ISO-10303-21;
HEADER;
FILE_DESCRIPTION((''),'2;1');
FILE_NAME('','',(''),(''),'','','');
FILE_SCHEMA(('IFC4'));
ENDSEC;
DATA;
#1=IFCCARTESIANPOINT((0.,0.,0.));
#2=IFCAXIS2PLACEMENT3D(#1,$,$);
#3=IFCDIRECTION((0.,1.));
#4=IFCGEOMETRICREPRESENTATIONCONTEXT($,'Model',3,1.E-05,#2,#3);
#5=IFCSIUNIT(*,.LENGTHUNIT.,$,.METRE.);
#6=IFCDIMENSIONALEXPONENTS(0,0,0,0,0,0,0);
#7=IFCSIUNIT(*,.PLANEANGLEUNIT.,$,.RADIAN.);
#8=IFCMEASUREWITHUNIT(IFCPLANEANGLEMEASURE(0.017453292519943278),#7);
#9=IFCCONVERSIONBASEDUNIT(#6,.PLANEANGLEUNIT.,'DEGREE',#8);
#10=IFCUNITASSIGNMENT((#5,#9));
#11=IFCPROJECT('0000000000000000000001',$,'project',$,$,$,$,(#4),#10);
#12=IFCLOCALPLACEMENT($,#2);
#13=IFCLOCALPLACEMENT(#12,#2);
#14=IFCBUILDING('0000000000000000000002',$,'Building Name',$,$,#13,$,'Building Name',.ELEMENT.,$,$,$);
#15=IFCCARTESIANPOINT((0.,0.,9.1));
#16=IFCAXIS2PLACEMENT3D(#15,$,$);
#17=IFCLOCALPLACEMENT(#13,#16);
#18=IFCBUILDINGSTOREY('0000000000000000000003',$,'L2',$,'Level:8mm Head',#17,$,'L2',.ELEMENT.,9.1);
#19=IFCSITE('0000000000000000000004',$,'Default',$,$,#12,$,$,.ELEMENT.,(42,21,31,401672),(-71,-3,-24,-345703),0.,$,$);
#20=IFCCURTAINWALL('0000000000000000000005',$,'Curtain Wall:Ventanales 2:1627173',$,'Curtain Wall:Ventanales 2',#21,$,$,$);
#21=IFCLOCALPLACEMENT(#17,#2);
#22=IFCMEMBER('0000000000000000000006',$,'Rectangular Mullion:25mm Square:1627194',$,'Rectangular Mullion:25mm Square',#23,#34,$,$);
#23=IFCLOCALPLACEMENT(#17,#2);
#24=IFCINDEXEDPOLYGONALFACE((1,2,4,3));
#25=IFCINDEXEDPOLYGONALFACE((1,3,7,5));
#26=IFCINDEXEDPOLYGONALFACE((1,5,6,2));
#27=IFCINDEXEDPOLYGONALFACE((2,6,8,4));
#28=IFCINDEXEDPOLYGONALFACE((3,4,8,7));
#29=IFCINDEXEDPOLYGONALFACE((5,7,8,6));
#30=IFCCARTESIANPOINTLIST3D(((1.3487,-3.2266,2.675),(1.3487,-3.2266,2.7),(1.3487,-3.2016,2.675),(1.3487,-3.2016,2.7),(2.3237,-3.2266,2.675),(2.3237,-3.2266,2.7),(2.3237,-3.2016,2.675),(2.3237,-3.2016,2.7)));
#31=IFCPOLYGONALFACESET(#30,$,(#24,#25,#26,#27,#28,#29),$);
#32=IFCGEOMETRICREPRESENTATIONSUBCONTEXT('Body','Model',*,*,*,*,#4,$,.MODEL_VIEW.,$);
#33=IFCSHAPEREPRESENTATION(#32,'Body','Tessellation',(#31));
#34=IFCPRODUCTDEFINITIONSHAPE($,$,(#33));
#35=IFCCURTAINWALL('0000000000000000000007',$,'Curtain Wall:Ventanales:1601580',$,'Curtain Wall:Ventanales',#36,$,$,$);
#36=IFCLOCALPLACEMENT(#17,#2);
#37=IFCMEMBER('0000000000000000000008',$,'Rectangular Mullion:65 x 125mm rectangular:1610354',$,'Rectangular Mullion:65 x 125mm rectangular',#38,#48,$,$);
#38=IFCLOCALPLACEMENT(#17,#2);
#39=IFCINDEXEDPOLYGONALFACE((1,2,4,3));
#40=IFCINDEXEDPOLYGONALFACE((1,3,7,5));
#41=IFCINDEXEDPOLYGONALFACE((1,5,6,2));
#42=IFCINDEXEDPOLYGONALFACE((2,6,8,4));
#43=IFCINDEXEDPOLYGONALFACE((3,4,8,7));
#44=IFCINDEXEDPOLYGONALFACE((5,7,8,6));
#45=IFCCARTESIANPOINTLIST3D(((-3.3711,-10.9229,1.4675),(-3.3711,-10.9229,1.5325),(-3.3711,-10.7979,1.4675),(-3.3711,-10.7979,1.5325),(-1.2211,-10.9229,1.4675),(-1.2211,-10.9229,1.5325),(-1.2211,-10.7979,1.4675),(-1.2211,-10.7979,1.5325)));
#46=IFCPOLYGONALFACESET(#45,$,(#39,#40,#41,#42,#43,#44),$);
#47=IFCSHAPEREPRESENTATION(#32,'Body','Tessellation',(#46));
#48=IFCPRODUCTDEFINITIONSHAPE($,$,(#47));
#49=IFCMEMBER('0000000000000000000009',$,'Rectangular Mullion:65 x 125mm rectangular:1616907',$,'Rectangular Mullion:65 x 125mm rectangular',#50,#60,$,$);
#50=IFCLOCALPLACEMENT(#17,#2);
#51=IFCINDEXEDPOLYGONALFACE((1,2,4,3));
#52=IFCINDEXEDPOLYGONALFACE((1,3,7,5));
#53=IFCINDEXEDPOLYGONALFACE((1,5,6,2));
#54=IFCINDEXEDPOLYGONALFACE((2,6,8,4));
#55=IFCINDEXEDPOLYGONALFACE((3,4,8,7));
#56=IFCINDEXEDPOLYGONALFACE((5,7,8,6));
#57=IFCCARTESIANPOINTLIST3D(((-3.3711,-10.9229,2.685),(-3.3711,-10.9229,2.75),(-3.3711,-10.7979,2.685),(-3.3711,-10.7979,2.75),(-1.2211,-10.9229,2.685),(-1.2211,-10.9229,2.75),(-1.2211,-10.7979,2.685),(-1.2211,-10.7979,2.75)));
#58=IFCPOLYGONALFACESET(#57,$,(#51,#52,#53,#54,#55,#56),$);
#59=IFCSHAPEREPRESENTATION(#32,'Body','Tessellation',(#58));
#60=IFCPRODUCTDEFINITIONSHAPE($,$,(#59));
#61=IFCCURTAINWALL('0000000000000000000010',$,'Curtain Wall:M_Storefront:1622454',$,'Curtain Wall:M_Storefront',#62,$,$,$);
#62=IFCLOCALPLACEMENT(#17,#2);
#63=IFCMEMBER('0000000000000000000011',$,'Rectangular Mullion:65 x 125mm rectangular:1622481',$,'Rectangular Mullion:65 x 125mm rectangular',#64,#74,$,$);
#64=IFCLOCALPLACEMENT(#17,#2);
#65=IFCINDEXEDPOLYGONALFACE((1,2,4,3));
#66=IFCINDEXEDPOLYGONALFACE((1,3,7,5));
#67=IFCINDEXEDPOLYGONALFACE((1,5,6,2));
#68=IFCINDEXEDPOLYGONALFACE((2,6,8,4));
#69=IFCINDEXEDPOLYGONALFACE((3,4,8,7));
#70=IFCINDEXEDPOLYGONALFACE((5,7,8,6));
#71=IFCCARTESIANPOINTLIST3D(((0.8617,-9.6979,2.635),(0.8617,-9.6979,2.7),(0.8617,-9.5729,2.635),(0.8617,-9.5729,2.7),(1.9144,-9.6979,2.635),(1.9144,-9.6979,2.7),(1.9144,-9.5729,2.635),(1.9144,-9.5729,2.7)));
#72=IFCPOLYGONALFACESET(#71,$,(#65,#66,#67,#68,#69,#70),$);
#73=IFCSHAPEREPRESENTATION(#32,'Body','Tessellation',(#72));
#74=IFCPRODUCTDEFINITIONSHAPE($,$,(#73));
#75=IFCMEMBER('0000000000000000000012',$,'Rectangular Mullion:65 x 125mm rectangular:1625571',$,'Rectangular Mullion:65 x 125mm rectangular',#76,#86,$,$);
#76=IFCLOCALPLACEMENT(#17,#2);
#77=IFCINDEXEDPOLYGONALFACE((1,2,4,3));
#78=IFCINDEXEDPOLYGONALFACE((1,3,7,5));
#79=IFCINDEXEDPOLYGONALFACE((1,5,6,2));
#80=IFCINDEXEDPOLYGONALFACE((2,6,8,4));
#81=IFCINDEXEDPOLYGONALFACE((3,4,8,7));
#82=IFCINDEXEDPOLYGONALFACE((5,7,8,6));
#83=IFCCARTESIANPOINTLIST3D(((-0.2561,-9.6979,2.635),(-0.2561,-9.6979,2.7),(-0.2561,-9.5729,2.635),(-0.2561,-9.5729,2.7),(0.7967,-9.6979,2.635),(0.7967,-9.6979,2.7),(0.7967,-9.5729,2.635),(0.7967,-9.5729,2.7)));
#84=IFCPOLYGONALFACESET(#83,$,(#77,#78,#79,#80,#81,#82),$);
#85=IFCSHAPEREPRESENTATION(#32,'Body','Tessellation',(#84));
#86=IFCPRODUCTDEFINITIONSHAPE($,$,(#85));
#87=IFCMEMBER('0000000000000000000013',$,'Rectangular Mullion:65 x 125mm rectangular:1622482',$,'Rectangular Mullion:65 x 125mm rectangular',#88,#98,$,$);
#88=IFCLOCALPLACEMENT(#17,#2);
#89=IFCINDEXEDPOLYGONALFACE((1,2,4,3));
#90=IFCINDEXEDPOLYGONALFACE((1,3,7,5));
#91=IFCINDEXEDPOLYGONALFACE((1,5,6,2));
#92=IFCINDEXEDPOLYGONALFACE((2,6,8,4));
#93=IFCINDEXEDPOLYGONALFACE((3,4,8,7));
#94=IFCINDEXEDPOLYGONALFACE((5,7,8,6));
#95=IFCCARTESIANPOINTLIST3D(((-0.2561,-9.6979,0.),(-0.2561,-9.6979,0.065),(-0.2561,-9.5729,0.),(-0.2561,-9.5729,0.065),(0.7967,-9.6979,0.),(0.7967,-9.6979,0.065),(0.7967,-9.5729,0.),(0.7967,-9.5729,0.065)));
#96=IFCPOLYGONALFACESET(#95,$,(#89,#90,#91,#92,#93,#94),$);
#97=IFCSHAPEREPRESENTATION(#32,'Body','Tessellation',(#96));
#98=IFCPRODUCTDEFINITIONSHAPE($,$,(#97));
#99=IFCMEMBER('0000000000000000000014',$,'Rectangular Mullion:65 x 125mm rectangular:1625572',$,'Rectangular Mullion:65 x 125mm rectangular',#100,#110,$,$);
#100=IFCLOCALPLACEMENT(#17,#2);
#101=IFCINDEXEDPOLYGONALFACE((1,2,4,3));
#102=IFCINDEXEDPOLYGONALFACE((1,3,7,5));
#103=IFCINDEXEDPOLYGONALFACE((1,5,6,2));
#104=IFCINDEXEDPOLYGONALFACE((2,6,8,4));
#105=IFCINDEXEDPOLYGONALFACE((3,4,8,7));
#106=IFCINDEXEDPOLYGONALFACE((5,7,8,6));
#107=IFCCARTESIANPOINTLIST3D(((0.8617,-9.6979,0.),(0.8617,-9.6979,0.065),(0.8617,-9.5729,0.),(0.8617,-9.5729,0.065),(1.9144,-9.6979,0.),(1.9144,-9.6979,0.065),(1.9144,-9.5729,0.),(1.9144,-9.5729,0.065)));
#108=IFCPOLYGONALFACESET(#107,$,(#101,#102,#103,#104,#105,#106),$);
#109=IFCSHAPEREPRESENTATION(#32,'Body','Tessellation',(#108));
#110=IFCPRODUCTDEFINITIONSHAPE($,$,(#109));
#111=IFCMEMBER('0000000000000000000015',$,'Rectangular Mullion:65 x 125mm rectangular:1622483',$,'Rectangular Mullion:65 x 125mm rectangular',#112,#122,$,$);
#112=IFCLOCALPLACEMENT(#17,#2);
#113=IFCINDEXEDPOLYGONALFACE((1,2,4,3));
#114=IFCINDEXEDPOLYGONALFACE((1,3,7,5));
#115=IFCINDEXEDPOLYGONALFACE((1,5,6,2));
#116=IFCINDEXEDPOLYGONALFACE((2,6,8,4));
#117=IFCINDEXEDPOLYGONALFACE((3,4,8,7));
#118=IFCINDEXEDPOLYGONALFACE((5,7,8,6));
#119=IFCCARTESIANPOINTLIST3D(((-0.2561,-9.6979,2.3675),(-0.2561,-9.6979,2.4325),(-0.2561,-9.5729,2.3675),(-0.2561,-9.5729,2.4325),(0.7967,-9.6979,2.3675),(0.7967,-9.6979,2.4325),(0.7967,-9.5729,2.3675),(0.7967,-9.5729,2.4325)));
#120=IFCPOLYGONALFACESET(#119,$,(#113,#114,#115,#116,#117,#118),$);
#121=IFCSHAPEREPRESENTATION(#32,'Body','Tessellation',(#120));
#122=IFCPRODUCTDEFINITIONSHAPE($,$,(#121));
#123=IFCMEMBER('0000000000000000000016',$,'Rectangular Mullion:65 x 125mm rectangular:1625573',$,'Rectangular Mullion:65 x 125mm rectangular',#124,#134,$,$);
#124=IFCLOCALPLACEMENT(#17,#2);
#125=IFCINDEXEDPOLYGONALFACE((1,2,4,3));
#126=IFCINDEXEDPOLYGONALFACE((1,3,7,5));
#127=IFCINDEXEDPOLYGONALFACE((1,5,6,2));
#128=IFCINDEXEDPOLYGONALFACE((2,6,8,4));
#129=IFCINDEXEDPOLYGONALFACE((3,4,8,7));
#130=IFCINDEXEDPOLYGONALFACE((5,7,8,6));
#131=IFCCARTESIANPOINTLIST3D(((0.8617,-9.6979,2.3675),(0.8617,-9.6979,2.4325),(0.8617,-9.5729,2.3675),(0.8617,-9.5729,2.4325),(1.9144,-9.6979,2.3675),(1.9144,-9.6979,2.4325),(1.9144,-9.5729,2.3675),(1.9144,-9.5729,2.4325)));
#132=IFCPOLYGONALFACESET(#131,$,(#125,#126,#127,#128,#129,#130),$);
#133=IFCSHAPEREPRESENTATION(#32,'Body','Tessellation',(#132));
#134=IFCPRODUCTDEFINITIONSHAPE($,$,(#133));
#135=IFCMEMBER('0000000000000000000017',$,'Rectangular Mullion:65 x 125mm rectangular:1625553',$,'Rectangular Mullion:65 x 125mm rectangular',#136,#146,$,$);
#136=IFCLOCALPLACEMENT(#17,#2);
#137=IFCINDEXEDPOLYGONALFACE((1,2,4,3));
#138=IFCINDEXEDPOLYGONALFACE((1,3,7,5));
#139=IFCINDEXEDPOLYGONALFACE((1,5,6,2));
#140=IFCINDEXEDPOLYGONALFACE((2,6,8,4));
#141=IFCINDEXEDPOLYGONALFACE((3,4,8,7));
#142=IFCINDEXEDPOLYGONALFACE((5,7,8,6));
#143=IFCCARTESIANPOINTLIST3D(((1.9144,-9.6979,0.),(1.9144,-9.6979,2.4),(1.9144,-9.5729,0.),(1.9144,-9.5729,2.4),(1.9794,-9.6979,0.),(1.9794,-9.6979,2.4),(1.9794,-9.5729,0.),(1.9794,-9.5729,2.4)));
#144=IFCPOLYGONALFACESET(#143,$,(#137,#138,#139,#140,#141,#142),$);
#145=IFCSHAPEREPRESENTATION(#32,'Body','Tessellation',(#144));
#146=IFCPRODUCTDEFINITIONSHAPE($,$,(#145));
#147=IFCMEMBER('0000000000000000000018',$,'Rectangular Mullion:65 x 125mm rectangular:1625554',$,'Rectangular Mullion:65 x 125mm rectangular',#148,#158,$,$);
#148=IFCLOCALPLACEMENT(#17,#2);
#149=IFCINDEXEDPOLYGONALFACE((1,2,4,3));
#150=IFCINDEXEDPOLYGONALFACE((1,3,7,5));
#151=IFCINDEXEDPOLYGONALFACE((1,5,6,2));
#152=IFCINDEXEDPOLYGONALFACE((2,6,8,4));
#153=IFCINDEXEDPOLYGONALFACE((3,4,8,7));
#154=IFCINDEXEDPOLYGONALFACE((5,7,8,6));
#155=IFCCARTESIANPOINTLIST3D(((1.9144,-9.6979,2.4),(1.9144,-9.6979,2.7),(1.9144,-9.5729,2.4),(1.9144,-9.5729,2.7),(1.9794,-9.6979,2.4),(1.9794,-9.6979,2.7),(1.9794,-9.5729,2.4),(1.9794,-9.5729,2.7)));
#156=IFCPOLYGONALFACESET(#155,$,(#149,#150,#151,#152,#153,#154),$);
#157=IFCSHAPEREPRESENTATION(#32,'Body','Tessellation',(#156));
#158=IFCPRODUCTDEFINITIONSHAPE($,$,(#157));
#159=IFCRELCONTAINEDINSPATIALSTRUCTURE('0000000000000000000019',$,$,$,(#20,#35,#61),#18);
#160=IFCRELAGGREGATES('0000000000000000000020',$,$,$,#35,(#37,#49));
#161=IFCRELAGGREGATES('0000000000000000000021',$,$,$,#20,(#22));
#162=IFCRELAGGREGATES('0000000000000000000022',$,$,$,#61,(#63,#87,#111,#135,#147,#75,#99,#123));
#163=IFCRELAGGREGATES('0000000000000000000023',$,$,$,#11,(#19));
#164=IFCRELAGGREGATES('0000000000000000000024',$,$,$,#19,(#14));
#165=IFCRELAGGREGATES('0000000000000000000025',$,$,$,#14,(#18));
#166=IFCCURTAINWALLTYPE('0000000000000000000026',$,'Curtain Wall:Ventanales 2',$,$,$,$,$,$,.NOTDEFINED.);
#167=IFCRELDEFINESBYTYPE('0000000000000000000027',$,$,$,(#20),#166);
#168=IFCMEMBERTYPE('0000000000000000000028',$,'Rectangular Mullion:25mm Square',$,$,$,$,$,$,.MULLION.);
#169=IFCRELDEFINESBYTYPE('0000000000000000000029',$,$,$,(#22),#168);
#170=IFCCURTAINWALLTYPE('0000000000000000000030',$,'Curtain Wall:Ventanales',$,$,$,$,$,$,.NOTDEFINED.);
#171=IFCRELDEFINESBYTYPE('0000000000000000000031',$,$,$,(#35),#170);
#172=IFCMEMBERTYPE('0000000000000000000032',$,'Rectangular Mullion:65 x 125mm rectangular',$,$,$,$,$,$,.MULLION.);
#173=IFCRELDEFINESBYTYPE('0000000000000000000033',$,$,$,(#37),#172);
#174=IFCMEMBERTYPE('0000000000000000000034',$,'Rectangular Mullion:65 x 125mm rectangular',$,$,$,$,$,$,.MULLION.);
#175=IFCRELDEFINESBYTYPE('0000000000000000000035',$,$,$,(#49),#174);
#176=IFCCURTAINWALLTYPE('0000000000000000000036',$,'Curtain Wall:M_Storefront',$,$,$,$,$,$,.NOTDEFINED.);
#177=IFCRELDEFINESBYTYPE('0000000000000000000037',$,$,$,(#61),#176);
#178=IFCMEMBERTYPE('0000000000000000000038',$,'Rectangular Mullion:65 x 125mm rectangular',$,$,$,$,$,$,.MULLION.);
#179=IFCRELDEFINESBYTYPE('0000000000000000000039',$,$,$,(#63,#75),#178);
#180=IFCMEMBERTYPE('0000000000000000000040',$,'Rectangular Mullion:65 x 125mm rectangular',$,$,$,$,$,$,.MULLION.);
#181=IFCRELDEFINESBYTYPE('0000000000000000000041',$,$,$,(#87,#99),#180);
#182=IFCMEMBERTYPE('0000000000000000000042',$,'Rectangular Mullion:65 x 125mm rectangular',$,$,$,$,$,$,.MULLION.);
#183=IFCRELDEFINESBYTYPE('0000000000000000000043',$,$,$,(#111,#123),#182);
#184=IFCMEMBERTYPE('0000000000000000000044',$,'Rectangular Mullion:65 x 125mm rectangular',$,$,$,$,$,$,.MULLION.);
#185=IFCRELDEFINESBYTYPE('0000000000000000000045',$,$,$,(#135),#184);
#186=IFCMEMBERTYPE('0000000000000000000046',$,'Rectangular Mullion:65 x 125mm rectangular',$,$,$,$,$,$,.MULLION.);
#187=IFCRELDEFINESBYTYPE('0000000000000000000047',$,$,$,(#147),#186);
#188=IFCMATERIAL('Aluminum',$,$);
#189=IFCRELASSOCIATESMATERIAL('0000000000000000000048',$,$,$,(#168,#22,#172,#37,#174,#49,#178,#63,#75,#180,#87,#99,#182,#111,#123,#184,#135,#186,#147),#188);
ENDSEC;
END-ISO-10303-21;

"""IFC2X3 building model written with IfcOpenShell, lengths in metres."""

from ifc_helpers import new_model, entity, si_unit, converted_unit, direction, frame, origin, origin_2d_with_axis, place, context, subcontext, project, spatial, rectangle, extrude, source, transform, mapped, material, type_object, type_shapes, element, aggregate, save


model = new_model("IFC2X3")

# Units and contexts
model_context = context("Model", 3, precision=1e-05, world=origin(), true_north=direction((0.0, 1.0)))
body_context = subcontext(model_context, "Body", "Model", "MODEL_VIEW")
ifc_project = project(units=[si_unit("LENGTHUNIT", "METRE"), converted_unit("PLANEANGLEUNIT", "DEGREE", entity("IfcPlaneAngleMeasure", 0.017453292519943278), si_unit("PLANEANGLEUNIT", "RADIAN"), dimensions=[0, 0, 0, 0, 0, 0, 0])], contexts=[model_context])

# Site, building, storey
site_placement = place(None, origin())
site = spatial("IfcSite", under=ifc_project, at=site_placement, Name="Default", CompositionType="ELEMENT", RefLatitude=(42, 21, 31, 401672), RefLongitude=(-71, -3, -24, -345703), RefElevation=0.0)
building_placement = place(site_placement, origin())
building = spatial("IfcBuilding", under=site, at=building_placement, Name="Building Name", LongName="Building Name", CompositionType="ELEMENT")
storey_placement = place(building_placement, frame((0.0, 0.0, 9.1)))
storey = spatial("IfcBuildingStorey", under=building, at=storey_placement, Name="L2", ObjectType="Level:8mm Head", LongName="L2", CompositionType="ELEMENT", Elevation=9.1)

# Curtain wall, member
curtain_wall_type_1 = type_object("IfcCurtainWallType", Name="Curtain Wall:Ventanales 2", PredefinedType="NOTDEFINED")
curtain_wall_1_placement = place(storey_placement, frame((0.0, 0.0, -9.1)))
curtain_wall_1 = element("IfcCurtainWall", 1, at=curtain_wall_1_placement, inside=storey, type_object=curtain_wall_type_1, Name="Curtain Wall:Ventanales 2:1627173", ObjectType="Curtain Wall:Ventanales 2")
ifc_material_1 = material(Name="Aluminum")
member_type_1 = type_object("IfcMemberType", Name="Rectangular Mullion:25mm Square", PredefinedType="MULLION", material=ifc_material_1)
shared_shape_1 = source(origin(), body_context, "Body", "SweptSolid", [
    extrude(rectangle(XDim=0.025, YDim=0.025, at=origin_2d_with_axis()), frame((-0.0125, 0.0, -0.975), z_axis=(0.0, 0.0, 1.0), x_axis=(-1.0, 0.0, 0.0)), (0.0, 0.0, 1.0), 0.975),
])
type_shapes(member_type_1, [shared_shape_1])
member_1_placement = place(curtain_wall_1_placement, frame((2.3237, -3.2141, 11.8), z_axis=(1.0, 0.0, 0.0), x_axis=(0.0, 0.0, 1.0)))
member_1 = element("IfcMember", 2, at=member_1_placement, type_object=member_type_1, material=ifc_material_1, Name="Rectangular Mullion:25mm Square:1627194", ObjectType="Rectangular Mullion:25mm Square", context=body_context, shape_type="MappedRepresentation", body=[
    mapped(shared_shape_1, transform((0.0, 0.0, 0.0), scale=1.0)),
])

# Curtain walls, members
curtain_wall_type_2 = type_object("IfcCurtainWallType", Name="Curtain Wall:Ventanales", PredefinedType="NOTDEFINED")
curtain_wall_2_placement = place(storey_placement, frame((0.0, 0.0, -9.1)))
curtain_wall_2 = element("IfcCurtainWall", 3, at=curtain_wall_2_placement, inside=storey, type_object=curtain_wall_type_2, Name="Curtain Wall:Ventanales:1601580", ObjectType="Curtain Wall:Ventanales")
member_type_2 = type_object("IfcMemberType", Name="Rectangular Mullion:65 x 125mm rectangular", PredefinedType="MULLION", material=ifc_material_1)
shared_shape_2 = source(origin(), body_context, "Body", "SweptSolid", [
    extrude(rectangle(XDim=0.065, YDim=0.125, at=origin_2d_with_axis()), frame((0.0, 0.0, -2.15), z_axis=(0.0, 0.0, 1.0), x_axis=(-1.0, 0.0, 0.0)), (0.0, 0.0, 1.0), 2.15),
])
type_shapes(member_type_2, [shared_shape_2])
member_2_placement = place(curtain_wall_2_placement, frame((-1.2211, -10.8604, 10.6), z_axis=(1.0, 0.0, 0.0), x_axis=(0.0, 0.0, 1.0)))
member_2 = element("IfcMember", 4, at=member_2_placement, type_object=member_type_2, material=ifc_material_1, Name="Rectangular Mullion:65 x 125mm rectangular:1610354", ObjectType="Rectangular Mullion:65 x 125mm rectangular", context=body_context, shape_type="MappedRepresentation", body=[
    mapped(shared_shape_2, transform((0.0, 0.0, 0.0), scale=1.0)),
])
member_type_3 = type_object("IfcMemberType", Name="Rectangular Mullion:65 x 125mm rectangular", PredefinedType="MULLION", material=ifc_material_1)
shared_shape_3 = source(origin(), body_context, "Body", "SweptSolid", [
    extrude(rectangle(XDim=0.065, YDim=0.125, at=origin_2d_with_axis()), frame((-0.0325, 0.0, -2.15), z_axis=(0.0, 0.0, 1.0), x_axis=(-1.0, 0.0, 0.0)), (0.0, 0.0, 1.0), 2.15),
])
type_shapes(member_type_3, [shared_shape_3])
member_3_placement = place(curtain_wall_2_placement, frame((-1.2211, -10.8604, 11.85), z_axis=(1.0, 0.0, 0.0), x_axis=(0.0, 0.0, 1.0)))
member_3 = element("IfcMember", 5, at=member_3_placement, type_object=member_type_3, material=ifc_material_1, Name="Rectangular Mullion:65 x 125mm rectangular:1616907", ObjectType="Rectangular Mullion:65 x 125mm rectangular", context=body_context, shape_type="MappedRepresentation", body=[
    mapped(shared_shape_3, transform((0.0, 0.0, 0.0), scale=1.0)),
])
aggregate(curtain_wall_2, [member_2, member_3])
curtain_wall_type_3 = type_object("IfcCurtainWallType", Name="Curtain Wall:M_Storefront", PredefinedType="NOTDEFINED")
curtain_wall_3_placement = place(storey_placement, frame((0.0, 0.0, -9.1)))
curtain_wall_3 = element("IfcCurtainWall", 6, at=curtain_wall_3_placement, inside=storey, type_object=curtain_wall_type_3, Name="Curtain Wall:M_Storefront:1622454", ObjectType="Curtain Wall:M_Storefront")
member_type_4 = type_object("IfcMemberType", Name="Rectangular Mullion:65 x 125mm rectangular", PredefinedType="MULLION", material=ifc_material_1)
shared_shape_4 = source(origin(), body_context, "Body", "SweptSolid", [
    extrude(rectangle(XDim=0.065, YDim=0.125, at=origin_2d_with_axis()), frame((-0.0325, 0.0, -1.0528), z_axis=(0.0, 0.0, 1.0), x_axis=(-1.0, 0.0, 0.0)), (0.0, 0.0, 1.0), 1.0528),
])
type_shapes(member_type_4, [shared_shape_4])
member_4_placement = place(curtain_wall_3_placement, frame((1.9144, -9.6354, 11.8), z_axis=(1.0, 0.0, 0.0), x_axis=(0.0, 0.0, 1.0)))
member_4 = element("IfcMember", 7, at=member_4_placement, type_object=member_type_4, material=ifc_material_1, Name="Rectangular Mullion:65 x 125mm rectangular:1622481", ObjectType="Rectangular Mullion:65 x 125mm rectangular", context=body_context, shape_type="MappedRepresentation", body=[
    mapped(shared_shape_4, transform((0.0, 0.0, 0.0), scale=1.0)),
])
member_5_placement = place(curtain_wall_3_placement, frame((0.7967, -9.6354, 11.8), z_axis=(1.0, 0.0, 0.0), x_axis=(0.0, 0.0, 1.0)))
member_5 = element("IfcMember", 8, at=member_5_placement, type_object=member_type_4, material=ifc_material_1, Name="Rectangular Mullion:65 x 125mm rectangular:1625571", ObjectType="Rectangular Mullion:65 x 125mm rectangular", context=body_context, shape_type="MappedRepresentation", body=[
    mapped(shared_shape_4, transform((0.0, 0.0, 0.0), scale=1.0)),
])
member_type_5 = type_object("IfcMemberType", Name="Rectangular Mullion:65 x 125mm rectangular", PredefinedType="MULLION", material=ifc_material_1)
shared_shape_5 = source(origin(), body_context, "Body", "SweptSolid", [
    extrude(rectangle(XDim=0.065, YDim=0.125, at=origin_2d_with_axis()), frame((-0.0325, 0.0, -1.0528), z_axis=(0.0, 0.0, 1.0), x_axis=(-1.0, 0.0, 0.0)), (0.0, 0.0, 1.0), 1.0528),
])
type_shapes(member_type_5, [shared_shape_5])
member_6_placement = place(curtain_wall_3_placement, frame((-0.2561, -9.6354, 9.1), z_axis=(-1.0, 0.0, 0.0), x_axis=(0.0, 0.0, -1.0)))
member_6 = element("IfcMember", 9, at=member_6_placement, type_object=member_type_5, material=ifc_material_1, Name="Rectangular Mullion:65 x 125mm rectangular:1622482", ObjectType="Rectangular Mullion:65 x 125mm rectangular", context=body_context, shape_type="MappedRepresentation", body=[
    mapped(shared_shape_5, transform((0.0, 0.0, 0.0), scale=1.0)),
])
member_7_placement = place(curtain_wall_3_placement, frame((0.8617, -9.6354, 9.1), z_axis=(-1.0, 0.0, 0.0), x_axis=(0.0, 0.0, -1.0)))
member_7 = element("IfcMember", 10, at=member_7_placement, type_object=member_type_5, material=ifc_material_1, Name="Rectangular Mullion:65 x 125mm rectangular:1625572", ObjectType="Rectangular Mullion:65 x 125mm rectangular", context=body_context, shape_type="MappedRepresentation", body=[
    mapped(shared_shape_5, transform((0.0, 0.0, 0.0), scale=1.0)),
])
member_type_6 = type_object("IfcMemberType", Name="Rectangular Mullion:65 x 125mm rectangular", PredefinedType="MULLION", material=ifc_material_1)
shared_shape_6 = source(origin(), body_context, "Body", "SweptSolid", [
    extrude(rectangle(XDim=0.065, YDim=0.125, at=origin_2d_with_axis()), frame((0.0, 0.0, -1.0528), z_axis=(0.0, 0.0, 1.0), x_axis=(-1.0, 0.0, 0.0)), (0.0, 0.0, 1.0), 1.0528),
])
type_shapes(member_type_6, [shared_shape_6])
member_8_placement = place(curtain_wall_3_placement, frame((0.7967, -9.6354, 11.5), z_axis=(1.0, 0.0, 0.0), x_axis=(0.0, 0.0, 1.0)))
member_8 = element("IfcMember", 11, at=member_8_placement, type_object=member_type_6, material=ifc_material_1, Name="Rectangular Mullion:65 x 125mm rectangular:1622483", ObjectType="Rectangular Mullion:65 x 125mm rectangular", context=body_context, shape_type="MappedRepresentation", body=[
    mapped(shared_shape_6, transform((0.0, 0.0, 0.0), scale=1.0)),
])
member_9_placement = place(curtain_wall_3_placement, frame((1.9144, -9.6354, 11.5), z_axis=(1.0, 0.0, 0.0), x_axis=(0.0, 0.0, 1.0)))
member_9 = element("IfcMember", 12, at=member_9_placement, type_object=member_type_6, material=ifc_material_1, Name="Rectangular Mullion:65 x 125mm rectangular:1625573", ObjectType="Rectangular Mullion:65 x 125mm rectangular", context=body_context, shape_type="MappedRepresentation", body=[
    mapped(shared_shape_6, transform((0.0, 0.0, 0.0), scale=1.0)),
])
member_type_7 = type_object("IfcMemberType", Name="Rectangular Mullion:65 x 125mm rectangular", PredefinedType="MULLION", material=ifc_material_1)
shared_shape_7 = source(origin(), body_context, "Body", "SweptSolid", [
    extrude(rectangle(XDim=0.065, YDim=0.125, at=origin_2d_with_axis()), frame((-0.0325, 0.0, -2.4), z_axis=(0.0, 0.0, 1.0), x_axis=(-1.0, 0.0, 0.0)), (0.0, 0.0, 1.0), 2.4),
])
type_shapes(member_type_7, [shared_shape_7])
member_10_placement = place(curtain_wall_3_placement, frame((1.9794, -9.6354, 9.1), z_axis=(0.0, 0.0, -1.0), x_axis=(1.0, 0.0, 0.0)))
member_10 = element("IfcMember", 13, at=member_10_placement, type_object=member_type_7, material=ifc_material_1, Name="Rectangular Mullion:65 x 125mm rectangular:1625553", ObjectType="Rectangular Mullion:65 x 125mm rectangular", context=body_context, shape_type="MappedRepresentation", body=[
    mapped(shared_shape_7, transform((0.0, 0.0, 0.0), scale=1.0)),
])
member_type_8 = type_object("IfcMemberType", Name="Rectangular Mullion:65 x 125mm rectangular", PredefinedType="MULLION", material=ifc_material_1)
shared_shape_8 = source(origin(), body_context, "Body", "SweptSolid", [
    extrude(rectangle(XDim=0.065, YDim=0.125, at=origin_2d_with_axis()), frame((-0.0325, 0.0, -0.3), z_axis=(0.0, 0.0, 1.0), x_axis=(-1.0, 0.0, 0.0)), (0.0, 0.0, 1.0), 0.3),
])
type_shapes(member_type_8, [shared_shape_8])
member_11_placement = place(curtain_wall_3_placement, frame((1.9794, -9.6354, 11.5), z_axis=(0.0, 0.0, -1.0), x_axis=(1.0, 0.0, 0.0)))
member_11 = element("IfcMember", 14, at=member_11_placement, type_object=member_type_8, material=ifc_material_1, Name="Rectangular Mullion:65 x 125mm rectangular:1625554", ObjectType="Rectangular Mullion:65 x 125mm rectangular", context=body_context, shape_type="MappedRepresentation", body=[
    mapped(shared_shape_8, transform((0.0, 0.0, 0.0), scale=1.0)),
])

aggregate(curtain_wall_1, [member_1])
aggregate(curtain_wall_3, [member_4, member_6, member_8, member_10, member_11, member_5, member_7, member_9])

save(model, "model.ifc")
